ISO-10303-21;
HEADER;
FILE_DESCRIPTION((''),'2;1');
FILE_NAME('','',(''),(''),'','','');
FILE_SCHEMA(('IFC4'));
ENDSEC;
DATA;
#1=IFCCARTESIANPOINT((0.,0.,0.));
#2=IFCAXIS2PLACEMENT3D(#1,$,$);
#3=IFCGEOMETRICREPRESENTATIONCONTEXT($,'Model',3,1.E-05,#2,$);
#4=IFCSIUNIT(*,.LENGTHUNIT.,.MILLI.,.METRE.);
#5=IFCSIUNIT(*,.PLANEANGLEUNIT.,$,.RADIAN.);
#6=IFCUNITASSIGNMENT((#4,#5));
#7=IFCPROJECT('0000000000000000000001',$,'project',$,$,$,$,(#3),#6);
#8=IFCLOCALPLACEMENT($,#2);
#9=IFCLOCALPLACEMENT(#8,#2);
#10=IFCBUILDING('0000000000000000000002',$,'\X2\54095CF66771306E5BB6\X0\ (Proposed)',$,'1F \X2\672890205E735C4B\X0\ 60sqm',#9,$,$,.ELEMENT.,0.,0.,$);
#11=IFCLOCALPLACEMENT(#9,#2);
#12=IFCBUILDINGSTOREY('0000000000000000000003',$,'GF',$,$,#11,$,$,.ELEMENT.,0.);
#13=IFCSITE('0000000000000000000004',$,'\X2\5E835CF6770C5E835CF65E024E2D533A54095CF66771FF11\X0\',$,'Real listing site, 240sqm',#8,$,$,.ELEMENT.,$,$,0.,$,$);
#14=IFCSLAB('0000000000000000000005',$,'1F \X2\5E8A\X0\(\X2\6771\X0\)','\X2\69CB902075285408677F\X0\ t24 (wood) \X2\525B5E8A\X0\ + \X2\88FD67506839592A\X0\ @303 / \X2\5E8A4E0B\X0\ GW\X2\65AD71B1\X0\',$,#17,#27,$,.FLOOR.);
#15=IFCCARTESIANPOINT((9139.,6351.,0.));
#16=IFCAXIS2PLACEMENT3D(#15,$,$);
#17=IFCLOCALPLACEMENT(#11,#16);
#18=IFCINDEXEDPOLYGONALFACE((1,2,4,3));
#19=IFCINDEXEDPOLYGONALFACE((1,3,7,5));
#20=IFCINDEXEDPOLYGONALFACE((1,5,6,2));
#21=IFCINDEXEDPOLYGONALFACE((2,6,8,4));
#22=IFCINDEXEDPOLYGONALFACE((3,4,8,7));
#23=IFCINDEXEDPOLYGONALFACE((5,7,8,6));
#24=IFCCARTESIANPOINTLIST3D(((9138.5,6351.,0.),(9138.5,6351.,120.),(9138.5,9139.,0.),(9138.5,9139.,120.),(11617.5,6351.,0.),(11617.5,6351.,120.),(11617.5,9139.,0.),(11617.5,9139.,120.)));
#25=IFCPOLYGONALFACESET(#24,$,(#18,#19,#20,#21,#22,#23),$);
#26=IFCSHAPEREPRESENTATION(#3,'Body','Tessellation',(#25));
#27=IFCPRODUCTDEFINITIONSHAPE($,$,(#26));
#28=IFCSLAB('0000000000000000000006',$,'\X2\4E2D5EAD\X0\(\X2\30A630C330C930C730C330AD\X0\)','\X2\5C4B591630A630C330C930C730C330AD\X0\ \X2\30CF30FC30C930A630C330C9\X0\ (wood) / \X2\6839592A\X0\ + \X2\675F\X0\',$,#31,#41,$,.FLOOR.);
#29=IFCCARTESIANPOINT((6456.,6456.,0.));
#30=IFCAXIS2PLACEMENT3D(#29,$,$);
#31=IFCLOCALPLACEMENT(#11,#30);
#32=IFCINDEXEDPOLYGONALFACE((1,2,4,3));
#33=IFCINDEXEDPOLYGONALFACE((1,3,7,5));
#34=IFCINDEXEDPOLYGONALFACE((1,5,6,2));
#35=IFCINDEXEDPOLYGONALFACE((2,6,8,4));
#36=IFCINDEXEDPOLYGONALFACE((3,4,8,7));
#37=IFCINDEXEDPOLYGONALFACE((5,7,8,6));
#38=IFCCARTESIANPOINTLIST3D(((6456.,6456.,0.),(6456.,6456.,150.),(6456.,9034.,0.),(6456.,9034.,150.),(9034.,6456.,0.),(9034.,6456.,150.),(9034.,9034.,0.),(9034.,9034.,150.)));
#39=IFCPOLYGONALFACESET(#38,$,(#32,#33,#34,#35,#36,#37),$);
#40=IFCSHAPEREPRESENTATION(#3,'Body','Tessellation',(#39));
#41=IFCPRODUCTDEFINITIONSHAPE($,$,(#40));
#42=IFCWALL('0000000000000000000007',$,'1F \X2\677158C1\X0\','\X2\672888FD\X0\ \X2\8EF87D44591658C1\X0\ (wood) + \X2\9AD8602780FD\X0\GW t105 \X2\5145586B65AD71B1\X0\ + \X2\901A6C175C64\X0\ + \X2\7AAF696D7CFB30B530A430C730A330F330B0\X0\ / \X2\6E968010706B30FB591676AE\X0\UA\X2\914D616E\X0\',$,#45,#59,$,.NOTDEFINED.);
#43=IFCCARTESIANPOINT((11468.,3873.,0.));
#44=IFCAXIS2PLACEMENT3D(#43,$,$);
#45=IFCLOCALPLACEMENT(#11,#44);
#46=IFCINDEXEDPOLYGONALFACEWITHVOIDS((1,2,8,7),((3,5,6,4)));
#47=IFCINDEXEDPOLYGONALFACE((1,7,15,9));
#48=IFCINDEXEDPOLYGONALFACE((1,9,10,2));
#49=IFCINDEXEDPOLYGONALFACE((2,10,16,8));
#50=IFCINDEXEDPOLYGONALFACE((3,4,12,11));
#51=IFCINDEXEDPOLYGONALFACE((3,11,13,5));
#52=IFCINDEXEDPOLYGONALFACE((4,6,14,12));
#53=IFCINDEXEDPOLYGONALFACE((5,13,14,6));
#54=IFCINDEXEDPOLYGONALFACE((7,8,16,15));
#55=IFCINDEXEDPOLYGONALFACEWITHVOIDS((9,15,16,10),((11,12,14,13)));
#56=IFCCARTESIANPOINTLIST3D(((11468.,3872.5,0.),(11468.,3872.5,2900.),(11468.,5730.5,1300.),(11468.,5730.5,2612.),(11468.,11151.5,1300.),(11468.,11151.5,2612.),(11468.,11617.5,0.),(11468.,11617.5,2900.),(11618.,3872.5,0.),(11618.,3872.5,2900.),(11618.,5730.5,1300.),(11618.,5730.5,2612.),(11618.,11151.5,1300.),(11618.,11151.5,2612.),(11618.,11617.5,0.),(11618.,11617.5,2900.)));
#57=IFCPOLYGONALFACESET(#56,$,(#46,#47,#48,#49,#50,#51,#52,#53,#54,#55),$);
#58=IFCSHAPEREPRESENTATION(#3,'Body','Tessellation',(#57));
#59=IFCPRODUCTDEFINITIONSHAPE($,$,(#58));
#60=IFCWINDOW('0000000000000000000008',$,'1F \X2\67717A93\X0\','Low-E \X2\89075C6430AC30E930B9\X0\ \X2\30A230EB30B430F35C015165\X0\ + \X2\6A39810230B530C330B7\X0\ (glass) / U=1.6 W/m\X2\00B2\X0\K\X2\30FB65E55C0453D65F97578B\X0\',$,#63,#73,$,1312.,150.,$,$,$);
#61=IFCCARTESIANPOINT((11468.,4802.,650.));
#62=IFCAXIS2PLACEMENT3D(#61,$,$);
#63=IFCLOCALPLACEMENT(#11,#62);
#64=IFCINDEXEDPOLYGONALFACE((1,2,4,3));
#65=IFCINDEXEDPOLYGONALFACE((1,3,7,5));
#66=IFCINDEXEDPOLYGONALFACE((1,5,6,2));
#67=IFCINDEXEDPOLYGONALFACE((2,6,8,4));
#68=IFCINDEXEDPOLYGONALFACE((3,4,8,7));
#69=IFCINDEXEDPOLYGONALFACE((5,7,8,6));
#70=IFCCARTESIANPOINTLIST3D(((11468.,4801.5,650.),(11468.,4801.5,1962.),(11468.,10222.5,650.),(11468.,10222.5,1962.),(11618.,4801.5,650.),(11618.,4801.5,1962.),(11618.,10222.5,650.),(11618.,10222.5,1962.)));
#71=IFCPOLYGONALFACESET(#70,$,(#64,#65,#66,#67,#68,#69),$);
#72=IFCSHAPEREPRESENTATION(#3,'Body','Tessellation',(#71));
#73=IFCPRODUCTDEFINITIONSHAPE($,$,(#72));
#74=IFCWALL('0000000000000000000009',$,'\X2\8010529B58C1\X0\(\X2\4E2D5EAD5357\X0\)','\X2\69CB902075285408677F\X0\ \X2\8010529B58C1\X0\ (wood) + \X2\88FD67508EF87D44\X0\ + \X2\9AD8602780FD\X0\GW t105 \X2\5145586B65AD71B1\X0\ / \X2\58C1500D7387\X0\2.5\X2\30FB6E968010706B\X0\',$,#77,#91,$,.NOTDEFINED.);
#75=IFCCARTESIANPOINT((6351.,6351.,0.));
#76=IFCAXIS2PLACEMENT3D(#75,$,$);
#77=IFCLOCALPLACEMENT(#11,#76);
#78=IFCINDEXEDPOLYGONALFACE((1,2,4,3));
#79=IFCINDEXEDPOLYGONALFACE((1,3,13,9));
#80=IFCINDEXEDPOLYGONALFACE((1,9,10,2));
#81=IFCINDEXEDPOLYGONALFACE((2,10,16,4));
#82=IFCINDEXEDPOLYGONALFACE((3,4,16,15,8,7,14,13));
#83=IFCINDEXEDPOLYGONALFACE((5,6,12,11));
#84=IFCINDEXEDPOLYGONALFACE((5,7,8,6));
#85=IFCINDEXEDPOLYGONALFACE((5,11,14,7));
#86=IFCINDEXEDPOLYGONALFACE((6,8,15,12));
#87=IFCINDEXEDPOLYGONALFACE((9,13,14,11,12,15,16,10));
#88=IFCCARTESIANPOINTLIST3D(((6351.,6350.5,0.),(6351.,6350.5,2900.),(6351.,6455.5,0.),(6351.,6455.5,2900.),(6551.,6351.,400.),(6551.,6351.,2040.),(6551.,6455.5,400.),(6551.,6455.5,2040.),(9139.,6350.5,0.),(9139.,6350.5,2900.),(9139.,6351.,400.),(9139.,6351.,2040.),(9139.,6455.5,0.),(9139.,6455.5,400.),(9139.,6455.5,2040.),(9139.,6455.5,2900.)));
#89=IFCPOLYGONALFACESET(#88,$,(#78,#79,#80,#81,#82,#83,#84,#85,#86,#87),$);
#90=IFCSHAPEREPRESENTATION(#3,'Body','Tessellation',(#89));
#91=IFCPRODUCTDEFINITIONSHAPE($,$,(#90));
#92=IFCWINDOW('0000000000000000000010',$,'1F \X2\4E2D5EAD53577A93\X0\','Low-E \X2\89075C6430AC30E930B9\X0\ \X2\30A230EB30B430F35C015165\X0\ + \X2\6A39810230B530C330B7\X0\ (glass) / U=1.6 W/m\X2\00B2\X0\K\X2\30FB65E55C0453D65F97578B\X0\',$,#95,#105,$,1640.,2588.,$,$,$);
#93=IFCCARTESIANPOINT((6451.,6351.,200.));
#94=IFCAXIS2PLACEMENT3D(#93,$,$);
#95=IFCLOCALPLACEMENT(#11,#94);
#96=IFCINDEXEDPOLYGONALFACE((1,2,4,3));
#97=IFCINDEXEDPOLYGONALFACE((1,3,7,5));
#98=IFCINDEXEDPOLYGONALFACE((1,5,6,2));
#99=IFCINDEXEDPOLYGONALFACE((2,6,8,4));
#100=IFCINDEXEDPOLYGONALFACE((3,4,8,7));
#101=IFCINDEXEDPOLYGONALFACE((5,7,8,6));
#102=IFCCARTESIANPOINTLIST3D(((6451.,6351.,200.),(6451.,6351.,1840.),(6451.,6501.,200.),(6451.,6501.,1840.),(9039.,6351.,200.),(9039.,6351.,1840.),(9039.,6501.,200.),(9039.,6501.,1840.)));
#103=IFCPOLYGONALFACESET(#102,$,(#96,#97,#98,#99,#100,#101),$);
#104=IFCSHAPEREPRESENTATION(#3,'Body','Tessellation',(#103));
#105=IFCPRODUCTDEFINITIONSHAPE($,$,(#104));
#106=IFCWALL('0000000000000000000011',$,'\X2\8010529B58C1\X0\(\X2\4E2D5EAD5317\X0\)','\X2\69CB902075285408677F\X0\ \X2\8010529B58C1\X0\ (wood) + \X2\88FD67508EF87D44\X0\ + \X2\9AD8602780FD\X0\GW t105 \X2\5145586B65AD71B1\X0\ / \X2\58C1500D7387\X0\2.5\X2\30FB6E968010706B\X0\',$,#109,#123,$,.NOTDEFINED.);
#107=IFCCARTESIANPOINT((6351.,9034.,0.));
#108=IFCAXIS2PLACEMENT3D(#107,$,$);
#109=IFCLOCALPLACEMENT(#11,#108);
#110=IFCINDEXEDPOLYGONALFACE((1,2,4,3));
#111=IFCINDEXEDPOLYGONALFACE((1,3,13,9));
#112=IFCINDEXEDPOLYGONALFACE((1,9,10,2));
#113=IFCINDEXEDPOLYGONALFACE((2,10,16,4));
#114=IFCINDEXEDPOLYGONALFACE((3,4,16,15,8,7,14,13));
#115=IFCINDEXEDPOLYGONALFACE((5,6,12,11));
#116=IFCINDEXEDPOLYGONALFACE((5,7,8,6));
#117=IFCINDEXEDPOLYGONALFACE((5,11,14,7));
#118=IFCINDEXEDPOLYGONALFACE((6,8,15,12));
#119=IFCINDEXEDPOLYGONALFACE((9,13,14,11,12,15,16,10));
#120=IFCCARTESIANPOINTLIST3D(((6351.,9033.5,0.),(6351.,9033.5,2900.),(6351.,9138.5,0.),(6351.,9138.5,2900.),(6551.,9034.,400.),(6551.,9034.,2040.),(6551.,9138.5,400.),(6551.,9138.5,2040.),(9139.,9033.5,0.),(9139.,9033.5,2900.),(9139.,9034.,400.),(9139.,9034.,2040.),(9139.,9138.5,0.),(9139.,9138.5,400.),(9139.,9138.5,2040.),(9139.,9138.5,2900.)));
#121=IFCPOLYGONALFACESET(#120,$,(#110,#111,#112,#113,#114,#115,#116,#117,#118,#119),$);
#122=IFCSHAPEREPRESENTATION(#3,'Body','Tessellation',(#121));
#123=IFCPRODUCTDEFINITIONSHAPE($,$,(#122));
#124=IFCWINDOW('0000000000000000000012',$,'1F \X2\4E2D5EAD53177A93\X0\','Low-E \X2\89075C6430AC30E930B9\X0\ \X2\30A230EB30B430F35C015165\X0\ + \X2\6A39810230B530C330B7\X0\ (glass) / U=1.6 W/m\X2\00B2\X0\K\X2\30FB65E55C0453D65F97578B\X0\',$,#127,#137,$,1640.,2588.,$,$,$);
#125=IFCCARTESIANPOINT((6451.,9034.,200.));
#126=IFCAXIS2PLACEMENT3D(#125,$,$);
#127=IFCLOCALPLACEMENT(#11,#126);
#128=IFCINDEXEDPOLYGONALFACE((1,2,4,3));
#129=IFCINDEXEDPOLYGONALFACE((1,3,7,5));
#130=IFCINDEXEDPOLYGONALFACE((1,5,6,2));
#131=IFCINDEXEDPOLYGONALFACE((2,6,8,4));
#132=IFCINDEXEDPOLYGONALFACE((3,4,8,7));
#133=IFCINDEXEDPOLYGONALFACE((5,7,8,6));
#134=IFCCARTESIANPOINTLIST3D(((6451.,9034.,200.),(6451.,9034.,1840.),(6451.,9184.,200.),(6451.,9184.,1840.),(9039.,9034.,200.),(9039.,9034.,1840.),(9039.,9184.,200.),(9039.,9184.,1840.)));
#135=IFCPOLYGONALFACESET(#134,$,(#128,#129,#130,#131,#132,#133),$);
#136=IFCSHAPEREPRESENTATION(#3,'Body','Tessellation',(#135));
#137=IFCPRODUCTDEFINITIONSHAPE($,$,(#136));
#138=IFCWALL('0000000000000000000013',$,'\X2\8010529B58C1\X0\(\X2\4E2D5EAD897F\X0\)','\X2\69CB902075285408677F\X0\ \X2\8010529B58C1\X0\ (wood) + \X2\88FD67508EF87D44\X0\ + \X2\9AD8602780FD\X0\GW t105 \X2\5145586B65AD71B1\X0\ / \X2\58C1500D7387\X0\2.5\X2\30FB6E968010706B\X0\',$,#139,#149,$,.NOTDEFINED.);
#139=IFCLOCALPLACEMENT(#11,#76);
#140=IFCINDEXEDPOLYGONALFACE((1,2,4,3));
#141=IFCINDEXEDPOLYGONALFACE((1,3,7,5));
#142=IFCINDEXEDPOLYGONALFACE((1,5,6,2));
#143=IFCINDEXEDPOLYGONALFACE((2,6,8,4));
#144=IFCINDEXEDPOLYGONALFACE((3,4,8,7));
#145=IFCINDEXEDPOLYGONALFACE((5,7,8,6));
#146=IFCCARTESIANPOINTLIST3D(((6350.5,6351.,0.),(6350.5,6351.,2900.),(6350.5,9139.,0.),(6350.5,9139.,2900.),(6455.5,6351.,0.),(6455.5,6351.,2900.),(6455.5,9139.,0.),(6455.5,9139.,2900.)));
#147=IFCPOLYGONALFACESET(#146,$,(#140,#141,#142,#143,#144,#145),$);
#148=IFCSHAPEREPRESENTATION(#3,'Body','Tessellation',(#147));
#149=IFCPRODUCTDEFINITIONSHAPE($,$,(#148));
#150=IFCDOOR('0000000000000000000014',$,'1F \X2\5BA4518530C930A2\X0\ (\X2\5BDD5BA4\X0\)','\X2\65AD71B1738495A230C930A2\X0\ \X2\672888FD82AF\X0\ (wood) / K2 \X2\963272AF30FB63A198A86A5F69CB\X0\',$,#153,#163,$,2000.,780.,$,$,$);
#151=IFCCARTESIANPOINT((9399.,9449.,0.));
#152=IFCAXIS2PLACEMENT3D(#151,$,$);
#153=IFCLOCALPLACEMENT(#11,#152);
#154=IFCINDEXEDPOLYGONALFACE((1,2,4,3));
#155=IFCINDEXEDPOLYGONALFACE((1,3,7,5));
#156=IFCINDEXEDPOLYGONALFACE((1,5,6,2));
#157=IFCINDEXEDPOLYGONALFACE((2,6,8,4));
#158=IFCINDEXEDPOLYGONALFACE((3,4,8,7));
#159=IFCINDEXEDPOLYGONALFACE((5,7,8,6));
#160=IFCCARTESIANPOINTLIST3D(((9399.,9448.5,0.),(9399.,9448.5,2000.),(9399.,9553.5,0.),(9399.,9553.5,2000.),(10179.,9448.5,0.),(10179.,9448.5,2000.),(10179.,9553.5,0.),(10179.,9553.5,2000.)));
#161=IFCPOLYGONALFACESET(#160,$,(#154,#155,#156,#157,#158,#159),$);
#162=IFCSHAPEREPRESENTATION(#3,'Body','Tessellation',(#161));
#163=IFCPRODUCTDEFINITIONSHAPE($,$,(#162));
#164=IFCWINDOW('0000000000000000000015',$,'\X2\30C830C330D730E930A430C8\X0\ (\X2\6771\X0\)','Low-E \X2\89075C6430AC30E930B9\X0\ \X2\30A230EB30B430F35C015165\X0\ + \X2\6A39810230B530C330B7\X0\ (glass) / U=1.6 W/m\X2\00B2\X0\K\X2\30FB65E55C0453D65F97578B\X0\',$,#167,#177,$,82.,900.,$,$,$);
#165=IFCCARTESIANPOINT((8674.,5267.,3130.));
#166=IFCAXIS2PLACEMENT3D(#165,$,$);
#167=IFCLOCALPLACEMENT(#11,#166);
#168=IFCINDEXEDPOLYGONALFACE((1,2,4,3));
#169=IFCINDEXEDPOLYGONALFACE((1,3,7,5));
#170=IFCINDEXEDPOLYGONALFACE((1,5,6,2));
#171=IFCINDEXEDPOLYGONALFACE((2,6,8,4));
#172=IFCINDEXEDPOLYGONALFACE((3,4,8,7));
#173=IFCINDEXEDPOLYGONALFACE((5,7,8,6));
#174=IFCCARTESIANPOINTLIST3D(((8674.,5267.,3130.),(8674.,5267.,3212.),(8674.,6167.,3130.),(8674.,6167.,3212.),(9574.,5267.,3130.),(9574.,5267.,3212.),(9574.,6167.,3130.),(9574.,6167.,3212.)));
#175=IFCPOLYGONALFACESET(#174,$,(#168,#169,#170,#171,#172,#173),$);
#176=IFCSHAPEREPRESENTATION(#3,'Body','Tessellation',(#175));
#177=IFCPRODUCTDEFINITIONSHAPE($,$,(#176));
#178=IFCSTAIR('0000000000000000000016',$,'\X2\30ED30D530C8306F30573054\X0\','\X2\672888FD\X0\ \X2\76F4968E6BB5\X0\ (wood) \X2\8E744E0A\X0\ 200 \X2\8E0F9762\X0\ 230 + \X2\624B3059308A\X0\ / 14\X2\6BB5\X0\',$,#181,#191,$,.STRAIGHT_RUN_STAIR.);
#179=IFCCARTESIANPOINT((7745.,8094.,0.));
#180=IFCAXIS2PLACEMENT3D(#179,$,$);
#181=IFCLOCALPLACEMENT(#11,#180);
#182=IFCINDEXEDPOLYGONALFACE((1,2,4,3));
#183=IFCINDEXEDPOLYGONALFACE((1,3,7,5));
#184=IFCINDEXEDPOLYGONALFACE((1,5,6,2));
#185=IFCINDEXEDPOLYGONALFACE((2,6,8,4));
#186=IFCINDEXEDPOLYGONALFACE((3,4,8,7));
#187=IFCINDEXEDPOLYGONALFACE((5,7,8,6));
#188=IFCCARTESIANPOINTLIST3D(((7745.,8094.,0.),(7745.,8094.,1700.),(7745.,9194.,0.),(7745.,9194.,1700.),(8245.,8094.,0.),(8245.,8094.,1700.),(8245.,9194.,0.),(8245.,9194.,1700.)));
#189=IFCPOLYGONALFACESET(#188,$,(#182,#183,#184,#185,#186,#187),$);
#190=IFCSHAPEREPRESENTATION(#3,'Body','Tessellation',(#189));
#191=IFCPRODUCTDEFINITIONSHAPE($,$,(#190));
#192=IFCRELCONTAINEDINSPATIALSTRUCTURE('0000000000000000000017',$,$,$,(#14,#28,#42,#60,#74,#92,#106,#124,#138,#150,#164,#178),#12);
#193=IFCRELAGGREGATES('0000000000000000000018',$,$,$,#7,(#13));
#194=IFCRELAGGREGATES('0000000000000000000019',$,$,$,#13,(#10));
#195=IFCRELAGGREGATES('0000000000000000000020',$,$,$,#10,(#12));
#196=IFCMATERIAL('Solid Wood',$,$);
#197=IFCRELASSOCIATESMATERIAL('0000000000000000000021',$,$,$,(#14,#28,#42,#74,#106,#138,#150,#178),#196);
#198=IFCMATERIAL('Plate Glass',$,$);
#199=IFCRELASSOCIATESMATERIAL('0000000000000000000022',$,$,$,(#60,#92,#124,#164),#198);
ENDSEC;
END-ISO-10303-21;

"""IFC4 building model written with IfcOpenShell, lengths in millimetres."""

from ifc_helpers import new_model, si_unit, frame, frame_2d, origin, place, context, project, spatial, rectangle, extrude, material, element, fill, save


model = new_model("IFC4")

# Units and contexts
model_context = context("Model", 3, precision=1e-05, world=origin())
ifc_project = project(units=[si_unit("LENGTHUNIT", "METRE", prefix="MILLI"), si_unit("PLANEANGLEUNIT", "RADIAN")], contexts=[model_context])

# Site, building, storey
site_placement = place(None, origin())
site = spatial("IfcSite", under=ifc_project, at=site_placement, Name="広島県広島市中区吉島東１", ObjectType="Real listing site, 240sqm", CompositionType="ELEMENT", RefElevation=0.0)
building_placement = place(site_placement, origin())
building = spatial("IfcBuilding", under=site, at=building_placement, Name="吉島東の家 (Proposed)", ObjectType="1F 木造平屋 60sqm", CompositionType="ELEMENT", ElevationOfRefHeight=0.0, ElevationOfTerrain=0.0)
storey_placement = place(building_placement, origin())
storey = spatial("IfcBuildingStorey", under=building, at=storey_placement, Name="GF", CompositionType="ELEMENT", Elevation=0.0)

# Slabs
ifc_material_1 = material(Name="Solid Wood")
slab_1_placement = place(storey_placement, frame((9139.0, 6351.0, 0.0)))
element("IfcSlab", 1, at=slab_1_placement, inside=storey, material=ifc_material_1, Name="1F 床(東)", Description="構造用合板 t24 (wood) 剛床 + 製材根太 @303 / 床下 GW断熱", PredefinedType="FLOOR", context=model_context, shape_type="SweptSolid", body=[
    extrude(rectangle(XDim=2479.0, YDim=2788.0, at=frame_2d((1239.0, 1394.0))), frame((9139.0, 6351.0, 0.0)), (0.0, 0.0, 1.0), 120.0),
])
slab_2_placement = place(storey_placement, frame((6456.0, 6456.0, 0.0)))
element("IfcSlab", 2, at=slab_2_placement, inside=storey, material=ifc_material_1, Name="中庭(ウッドデッキ)", Description="屋外ウッドデッキ ハードウッド (wood) / 根太 + 束", PredefinedType="FLOOR", context=model_context, shape_type="SweptSolid", body=[
    extrude(rectangle(XDim=2578.0, YDim=2578.0, at=frame_2d((1289.0, 1289.0))), frame((6456.0, 6456.0, 0.0)), (0.0, 0.0, 1.0), 150.0),
])

# Walls, openings, windows
wall_1_placement = place(storey_placement, frame((11468.0, 3873.0, 0.0)))
wall_1 = element("IfcWall", 3, at=wall_1_placement, inside=storey, material=ifc_material_1, Name="1F 東壁", Description="木製 軸組外壁 (wood) + 高性能GW t105 充填断熱 + 通気層 + 窯業系サイディング / 準耐火・外皮UA配慮", PredefinedType="NOTDEFINED", context=model_context, shape_type="SweptSolid", body=[
    extrude(rectangle(XDim=150.0, YDim=7745.0, at=frame_2d((75.0, 3872.0))), frame((11468.0, 3873.0, 0.0)), (0.0, 0.0, 1.0), 2900.0),
])
opening_1_placement = place(storey_placement, frame((11468.0, 4802.0, 650.0)))
opening_1 = element("IfcOpeningElement", 4, at=opening_1_placement, cuts=wall_1, PredefinedType="NOTDEFINED", context=model_context, shape_type="SweptSolid", body=[
    extrude(rectangle(XDim=150.0, YDim=5421.0, at=frame_2d((75.0, 2710.0))), frame((11468.0, 4802.0, 650.0)), (0.0, 0.0, 1.0), 1312.0),
])
ifc_material_2 = material(Name="Plate Glass")
window_1_placement = place(storey_placement, frame((11468.0, 4802.0, 650.0)))
window_1 = element("IfcWindow", 5, at=window_1_placement, inside=storey, material=ifc_material_2, Name="1F 東窓", Description="Low-E 複層ガラス アルゴン封入 + 樹脂サッシ (glass) / U=1.6 W/m²K・日射取得型", OverallHeight=1312.0, OverallWidth=150.0, context=model_context, shape_type="SweptSolid", body=[
    extrude(rectangle(XDim=150.0, YDim=5421.0, at=frame_2d((75.0, 2710.0))), frame((11468.0, 4802.0, 650.0)), (0.0, 0.0, 1.0), 1312.0),
])
fill(opening_1, window_1)
wall_2_placement = place(storey_placement, frame((6351.0, 6351.0, 0.0)))
wall_2 = element("IfcWall", 6, at=wall_2_placement, inside=storey, material=ifc_material_1, Name="耐力壁(中庭南)", Description="構造用合板 耐力壁 (wood) + 製材軸組 + 高性能GW t105 充填断熱 / 壁倍率2.5・準耐火", PredefinedType="NOTDEFINED", context=model_context, shape_type="SweptSolid", body=[
    extrude(rectangle(XDim=2788.0, YDim=105.0, at=frame_2d((1394.0, 52.0))), frame((6351.0, 6351.0, 0.0)), (0.0, 0.0, 1.0), 2900.0),
])
opening_2_placement = place(storey_placement, frame((6451.0, 6351.0, 200.0)))
opening_2 = element("IfcOpeningElement", 7, at=opening_2_placement, cuts=wall_2, PredefinedType="NOTDEFINED", context=model_context, shape_type="SweptSolid", body=[
    extrude(rectangle(XDim=2588.0, YDim=150.0, at=frame_2d((1294.0, 75.0))), frame((6451.0, 6351.0, 200.0)), (0.0, 0.0, 1.0), 1640.0),
])
window_2_placement = place(storey_placement, frame((6451.0, 6351.0, 200.0)))
window_2 = element("IfcWindow", 8, at=window_2_placement, inside=storey, material=ifc_material_2, Name="1F 中庭南窓", Description="Low-E 複層ガラス アルゴン封入 + 樹脂サッシ (glass) / U=1.6 W/m²K・日射取得型", OverallHeight=1640.0, OverallWidth=2588.0, context=model_context, shape_type="SweptSolid", body=[
    extrude(rectangle(XDim=2588.0, YDim=150.0, at=frame_2d((1294.0, 75.0))), frame((6451.0, 6351.0, 200.0)), (0.0, 0.0, 1.0), 1640.0),
])
fill(opening_2, window_2)
wall_3_placement = place(storey_placement, frame((6351.0, 9034.0, 0.0)))
wall_3 = element("IfcWall", 9, at=wall_3_placement, inside=storey, material=ifc_material_1, Name="耐力壁(中庭北)", Description="構造用合板 耐力壁 (wood) + 製材軸組 + 高性能GW t105 充填断熱 / 壁倍率2.5・準耐火", PredefinedType="NOTDEFINED", context=model_context, shape_type="SweptSolid", body=[
    extrude(rectangle(XDim=2788.0, YDim=105.0, at=frame_2d((1394.0, 52.0))), frame((6351.0, 9034.0, 0.0)), (0.0, 0.0, 1.0), 2900.0),
])
opening_3_placement = place(storey_placement, frame((6451.0, 9034.0, 200.0)))
opening_3 = element("IfcOpeningElement", 10, at=opening_3_placement, cuts=wall_3, PredefinedType="NOTDEFINED", context=model_context, shape_type="SweptSolid", body=[
    extrude(rectangle(XDim=2588.0, YDim=150.0, at=frame_2d((1294.0, 75.0))), frame((6451.0, 9034.0, 200.0)), (0.0, 0.0, 1.0), 1640.0),
])
window_3_placement = place(storey_placement, frame((6451.0, 9034.0, 200.0)))
window_3 = element("IfcWindow", 11, at=window_3_placement, inside=storey, material=ifc_material_2, Name="1F 中庭北窓", Description="Low-E 複層ガラス アルゴン封入 + 樹脂サッシ (glass) / U=1.6 W/m²K・日射取得型", OverallHeight=1640.0, OverallWidth=2588.0, context=model_context, shape_type="SweptSolid", body=[
    extrude(rectangle(XDim=2588.0, YDim=150.0, at=frame_2d((1294.0, 75.0))), frame((6451.0, 9034.0, 200.0)), (0.0, 0.0, 1.0), 1640.0),
])
fill(opening_3, window_3)

# Wall
wall_4_placement = place(storey_placement, frame((6351.0, 6351.0, 0.0)))
element("IfcWall", 12, at=wall_4_placement, inside=storey, material=ifc_material_1, Name="耐力壁(中庭西)", Description="構造用合板 耐力壁 (wood) + 製材軸組 + 高性能GW t105 充填断熱 / 壁倍率2.5・準耐火", PredefinedType="NOTDEFINED", context=model_context, shape_type="SweptSolid", body=[
    extrude(rectangle(XDim=105.0, YDim=2788.0, at=frame_2d((52.0, 1394.0))), frame((6351.0, 6351.0, 0.0)), (0.0, 0.0, 1.0), 2900.0),
])

# Door
door_placement = place(storey_placement, frame((9399.0, 9449.0, 0.0)))
element("IfcDoor", 13, at=door_placement, inside=storey, material=ifc_material_1, Name="1F 室内ドア (寝室)", Description="断熱玄関ドア 木製芯 (wood) / K2 防犯・採風機構", OverallHeight=2000.0, OverallWidth=780.0, context=model_context, shape_type="SweptSolid", body=[
    extrude(rectangle(XDim=780.0, YDim=105.0, at=frame_2d((390.0, 52.0))), frame((9399.0, 9449.0, 0.0)), (0.0, 0.0, 1.0), 2000.0),
])

# Window
window_4_placement = place(storey_placement, frame((8674.0, 5267.0, 3130.0)))
element("IfcWindow", 14, at=window_4_placement, inside=storey, material=ifc_material_2, Name="トップライト (東)", Description="Low-E 複層ガラス アルゴン封入 + 樹脂サッシ (glass) / U=1.6 W/m²K・日射取得型", OverallHeight=82.0, OverallWidth=900.0, context=model_context, shape_type="SweptSolid", body=[
    extrude(rectangle(XDim=900.0, YDim=900.0, at=frame_2d((450.0, 450.0))), frame((8674.0, 5267.0, 3130.0)), (0.0, 0.0, 1.0), 82.0),
])

# Stair
stair_placement = place(storey_placement, frame((7745.0, 8094.0, 0.0)))
element("IfcStair", 15, at=stair_placement, inside=storey, material=ifc_material_1, Name="ロフトはしご", Description="木製 直階段 (wood) 蹴上 200 踏面 230 + 手すり / 14段", PredefinedType="STRAIGHT_RUN_STAIR", context=model_context, shape_type="SweptSolid", body=[
    extrude(rectangle(XDim=500.0, YDim=1100.0, at=frame_2d((250.0, 550.0))), frame((7745.0, 8094.0, 0.0)), (0.0, 0.0, 1.0), 1700.0),
])

save(model, "model.ifc")
